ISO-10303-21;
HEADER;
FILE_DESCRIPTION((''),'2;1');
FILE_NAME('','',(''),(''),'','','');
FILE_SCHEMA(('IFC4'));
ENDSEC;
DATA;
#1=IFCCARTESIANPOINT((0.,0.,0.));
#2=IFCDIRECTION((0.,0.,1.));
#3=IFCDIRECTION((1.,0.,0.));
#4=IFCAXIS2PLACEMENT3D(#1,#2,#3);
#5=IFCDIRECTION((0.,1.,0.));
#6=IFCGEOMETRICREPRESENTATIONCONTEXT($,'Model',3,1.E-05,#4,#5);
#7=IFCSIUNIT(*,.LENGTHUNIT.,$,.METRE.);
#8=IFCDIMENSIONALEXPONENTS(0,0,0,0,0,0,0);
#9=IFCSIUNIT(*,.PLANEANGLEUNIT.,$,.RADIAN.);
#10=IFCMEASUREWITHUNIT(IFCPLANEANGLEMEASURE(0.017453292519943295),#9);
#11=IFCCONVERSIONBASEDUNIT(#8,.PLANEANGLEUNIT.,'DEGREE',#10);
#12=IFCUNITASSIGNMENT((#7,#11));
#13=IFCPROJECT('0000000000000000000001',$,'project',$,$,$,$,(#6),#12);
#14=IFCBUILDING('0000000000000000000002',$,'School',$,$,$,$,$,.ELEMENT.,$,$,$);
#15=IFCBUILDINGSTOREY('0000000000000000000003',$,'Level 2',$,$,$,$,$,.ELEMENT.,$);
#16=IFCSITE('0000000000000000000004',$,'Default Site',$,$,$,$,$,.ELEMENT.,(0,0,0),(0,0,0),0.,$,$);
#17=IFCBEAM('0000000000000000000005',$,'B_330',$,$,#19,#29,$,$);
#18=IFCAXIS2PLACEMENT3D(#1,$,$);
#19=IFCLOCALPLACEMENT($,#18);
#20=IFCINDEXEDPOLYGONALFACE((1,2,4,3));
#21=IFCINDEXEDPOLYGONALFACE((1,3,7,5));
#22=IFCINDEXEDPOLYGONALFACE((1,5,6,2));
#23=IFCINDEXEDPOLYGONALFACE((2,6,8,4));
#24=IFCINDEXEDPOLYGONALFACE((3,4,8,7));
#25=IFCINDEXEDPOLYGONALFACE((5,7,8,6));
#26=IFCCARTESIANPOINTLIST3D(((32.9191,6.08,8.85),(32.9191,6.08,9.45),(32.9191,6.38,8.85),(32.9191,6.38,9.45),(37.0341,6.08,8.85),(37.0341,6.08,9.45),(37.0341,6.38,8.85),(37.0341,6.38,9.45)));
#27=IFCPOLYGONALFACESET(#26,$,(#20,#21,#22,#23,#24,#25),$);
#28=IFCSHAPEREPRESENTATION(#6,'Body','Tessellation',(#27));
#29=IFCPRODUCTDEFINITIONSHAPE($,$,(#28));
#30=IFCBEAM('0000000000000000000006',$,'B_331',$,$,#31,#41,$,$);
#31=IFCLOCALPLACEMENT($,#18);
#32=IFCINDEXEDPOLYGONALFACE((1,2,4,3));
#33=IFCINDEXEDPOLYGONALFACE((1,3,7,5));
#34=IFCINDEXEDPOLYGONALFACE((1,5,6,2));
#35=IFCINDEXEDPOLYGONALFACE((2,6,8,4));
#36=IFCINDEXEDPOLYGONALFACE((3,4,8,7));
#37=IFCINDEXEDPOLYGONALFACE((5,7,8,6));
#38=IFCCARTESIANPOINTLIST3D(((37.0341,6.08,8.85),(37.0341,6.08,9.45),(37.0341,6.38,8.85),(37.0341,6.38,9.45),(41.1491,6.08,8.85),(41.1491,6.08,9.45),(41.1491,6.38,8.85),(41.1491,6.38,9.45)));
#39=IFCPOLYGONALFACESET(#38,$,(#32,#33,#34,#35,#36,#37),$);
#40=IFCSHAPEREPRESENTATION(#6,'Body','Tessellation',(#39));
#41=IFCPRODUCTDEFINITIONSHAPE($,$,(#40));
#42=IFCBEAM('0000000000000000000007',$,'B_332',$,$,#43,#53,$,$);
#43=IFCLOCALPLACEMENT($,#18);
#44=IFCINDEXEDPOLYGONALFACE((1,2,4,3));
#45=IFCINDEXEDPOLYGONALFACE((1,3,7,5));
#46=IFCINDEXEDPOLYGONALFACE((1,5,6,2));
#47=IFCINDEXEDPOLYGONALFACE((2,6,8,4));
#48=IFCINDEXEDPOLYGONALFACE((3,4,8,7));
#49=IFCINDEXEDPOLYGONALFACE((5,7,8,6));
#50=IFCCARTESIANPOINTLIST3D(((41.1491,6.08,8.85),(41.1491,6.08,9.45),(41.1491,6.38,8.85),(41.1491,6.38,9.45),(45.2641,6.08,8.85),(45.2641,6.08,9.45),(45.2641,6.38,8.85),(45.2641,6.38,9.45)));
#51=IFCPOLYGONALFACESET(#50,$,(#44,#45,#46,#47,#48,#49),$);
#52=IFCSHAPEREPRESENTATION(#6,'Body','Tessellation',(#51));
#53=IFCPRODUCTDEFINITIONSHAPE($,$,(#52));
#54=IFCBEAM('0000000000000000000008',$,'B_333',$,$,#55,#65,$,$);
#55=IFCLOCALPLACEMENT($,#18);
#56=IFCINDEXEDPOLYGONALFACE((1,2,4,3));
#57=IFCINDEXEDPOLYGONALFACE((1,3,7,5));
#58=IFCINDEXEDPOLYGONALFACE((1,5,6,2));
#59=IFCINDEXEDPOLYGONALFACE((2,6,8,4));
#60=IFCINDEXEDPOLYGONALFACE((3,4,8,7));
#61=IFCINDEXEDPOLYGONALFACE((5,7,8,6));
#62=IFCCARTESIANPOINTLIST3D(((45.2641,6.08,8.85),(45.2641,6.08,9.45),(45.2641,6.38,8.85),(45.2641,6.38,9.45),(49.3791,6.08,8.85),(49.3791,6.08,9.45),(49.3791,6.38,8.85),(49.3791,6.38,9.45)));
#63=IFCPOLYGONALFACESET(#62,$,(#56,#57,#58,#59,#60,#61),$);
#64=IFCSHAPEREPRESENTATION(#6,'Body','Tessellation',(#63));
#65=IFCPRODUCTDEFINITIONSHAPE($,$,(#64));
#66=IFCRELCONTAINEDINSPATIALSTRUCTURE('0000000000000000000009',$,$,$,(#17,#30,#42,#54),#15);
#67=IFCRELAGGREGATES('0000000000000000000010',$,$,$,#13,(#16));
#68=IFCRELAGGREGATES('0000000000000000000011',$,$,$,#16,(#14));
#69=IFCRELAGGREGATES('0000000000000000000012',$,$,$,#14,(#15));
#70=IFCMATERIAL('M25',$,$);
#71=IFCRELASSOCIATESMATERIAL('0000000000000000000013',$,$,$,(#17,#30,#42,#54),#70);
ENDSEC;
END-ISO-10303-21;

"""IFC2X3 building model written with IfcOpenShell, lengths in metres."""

from ifc_helpers import new_model, entity, si_unit, converted_unit, direction, frame, frame_2d, origin_with_axes, place, context, project, spatial, rectangle, extrude, material, element, save


model = new_model("IFC2X3")

# Units and contexts
model_context = context("Model", 3, precision=1e-05, world=origin_with_axes(), true_north=direction((0.0, 1.0, 0.0)))
ifc_project = project(units=[si_unit("LENGTHUNIT", "METRE"), converted_unit("PLANEANGLEUNIT", "DEGREE", entity("IfcPlaneAngleMeasure", 0.017453292519943295), si_unit("PLANEANGLEUNIT", "RADIAN"), dimensions=[0, 0, 0, 0, 0, 0, 0])], contexts=[model_context])

# Site, building, storey
site = spatial("IfcSite", under=ifc_project, Name="Default Site", CompositionType="ELEMENT", RefLatitude=(0, 0, 0), RefLongitude=(0, 0, 0), RefElevation=0.0)
building = spatial("IfcBuilding", under=site, Name="School", CompositionType="ELEMENT")
storey = spatial("IfcBuildingStorey", under=building, Name="Level 2", CompositionType="ELEMENT")

# Shared definitions
ifc_material = material(Name="M25")
placement = place(None, origin_with_axes())

# Beams
element("IfcBeam", 1, at=placement, inside=storey, material=ifc_material, Name="B_330", context=model_context, shape_type="SweptSolid", body=[
    extrude(rectangle(XDim=0.3, YDim=0.6, at=frame_2d((0.0, 0.0), x_axis=(0.0, 1.0, 0.0))), frame((32.9191, 6.23, 9.15), z_axis=(1.0, 0.0, 0.0), x_axis=(0.0, 0.0, -1.0)), (0.0, 0.0, 1.0), 4.115),
])
element("IfcBeam", 2, at=placement, inside=storey, material=ifc_material, Name="B_331", context=model_context, shape_type="SweptSolid", body=[
    extrude(rectangle(XDim=0.3, YDim=0.6, at=frame_2d((0.0, 0.0), x_axis=(0.0, 1.0, 0.0))), frame((37.0341, 6.23, 9.15), z_axis=(1.0, 0.0, 0.0), x_axis=(0.0, 0.0, -1.0)), (0.0, 0.0, 1.0), 4.115),
])
element("IfcBeam", 3, at=placement, inside=storey, material=ifc_material, Name="B_332", context=model_context, shape_type="SweptSolid", body=[
    extrude(rectangle(XDim=0.3, YDim=0.6, at=frame_2d((0.0, 0.0), x_axis=(0.0, 1.0, 0.0))), frame((41.1491, 6.23, 9.15), z_axis=(1.0, 0.0, 0.0), x_axis=(0.0, 0.0, -1.0)), (0.0, 0.0, 1.0), 4.115),
])
element("IfcBeam", 4, at=placement, inside=storey, material=ifc_material, Name="B_333", context=model_context, shape_type="SweptSolid", body=[
    extrude(rectangle(XDim=0.3, YDim=0.6, at=frame_2d((0.0, 0.0), x_axis=(0.0, 1.0, 0.0))), frame((45.2641, 6.23, 9.15), z_axis=(1.0, 0.0, 0.0), x_axis=(0.0, 0.0, -1.0)), (0.0, 0.0, 1.0), 4.115),
])

save(model, "model.ifc")
